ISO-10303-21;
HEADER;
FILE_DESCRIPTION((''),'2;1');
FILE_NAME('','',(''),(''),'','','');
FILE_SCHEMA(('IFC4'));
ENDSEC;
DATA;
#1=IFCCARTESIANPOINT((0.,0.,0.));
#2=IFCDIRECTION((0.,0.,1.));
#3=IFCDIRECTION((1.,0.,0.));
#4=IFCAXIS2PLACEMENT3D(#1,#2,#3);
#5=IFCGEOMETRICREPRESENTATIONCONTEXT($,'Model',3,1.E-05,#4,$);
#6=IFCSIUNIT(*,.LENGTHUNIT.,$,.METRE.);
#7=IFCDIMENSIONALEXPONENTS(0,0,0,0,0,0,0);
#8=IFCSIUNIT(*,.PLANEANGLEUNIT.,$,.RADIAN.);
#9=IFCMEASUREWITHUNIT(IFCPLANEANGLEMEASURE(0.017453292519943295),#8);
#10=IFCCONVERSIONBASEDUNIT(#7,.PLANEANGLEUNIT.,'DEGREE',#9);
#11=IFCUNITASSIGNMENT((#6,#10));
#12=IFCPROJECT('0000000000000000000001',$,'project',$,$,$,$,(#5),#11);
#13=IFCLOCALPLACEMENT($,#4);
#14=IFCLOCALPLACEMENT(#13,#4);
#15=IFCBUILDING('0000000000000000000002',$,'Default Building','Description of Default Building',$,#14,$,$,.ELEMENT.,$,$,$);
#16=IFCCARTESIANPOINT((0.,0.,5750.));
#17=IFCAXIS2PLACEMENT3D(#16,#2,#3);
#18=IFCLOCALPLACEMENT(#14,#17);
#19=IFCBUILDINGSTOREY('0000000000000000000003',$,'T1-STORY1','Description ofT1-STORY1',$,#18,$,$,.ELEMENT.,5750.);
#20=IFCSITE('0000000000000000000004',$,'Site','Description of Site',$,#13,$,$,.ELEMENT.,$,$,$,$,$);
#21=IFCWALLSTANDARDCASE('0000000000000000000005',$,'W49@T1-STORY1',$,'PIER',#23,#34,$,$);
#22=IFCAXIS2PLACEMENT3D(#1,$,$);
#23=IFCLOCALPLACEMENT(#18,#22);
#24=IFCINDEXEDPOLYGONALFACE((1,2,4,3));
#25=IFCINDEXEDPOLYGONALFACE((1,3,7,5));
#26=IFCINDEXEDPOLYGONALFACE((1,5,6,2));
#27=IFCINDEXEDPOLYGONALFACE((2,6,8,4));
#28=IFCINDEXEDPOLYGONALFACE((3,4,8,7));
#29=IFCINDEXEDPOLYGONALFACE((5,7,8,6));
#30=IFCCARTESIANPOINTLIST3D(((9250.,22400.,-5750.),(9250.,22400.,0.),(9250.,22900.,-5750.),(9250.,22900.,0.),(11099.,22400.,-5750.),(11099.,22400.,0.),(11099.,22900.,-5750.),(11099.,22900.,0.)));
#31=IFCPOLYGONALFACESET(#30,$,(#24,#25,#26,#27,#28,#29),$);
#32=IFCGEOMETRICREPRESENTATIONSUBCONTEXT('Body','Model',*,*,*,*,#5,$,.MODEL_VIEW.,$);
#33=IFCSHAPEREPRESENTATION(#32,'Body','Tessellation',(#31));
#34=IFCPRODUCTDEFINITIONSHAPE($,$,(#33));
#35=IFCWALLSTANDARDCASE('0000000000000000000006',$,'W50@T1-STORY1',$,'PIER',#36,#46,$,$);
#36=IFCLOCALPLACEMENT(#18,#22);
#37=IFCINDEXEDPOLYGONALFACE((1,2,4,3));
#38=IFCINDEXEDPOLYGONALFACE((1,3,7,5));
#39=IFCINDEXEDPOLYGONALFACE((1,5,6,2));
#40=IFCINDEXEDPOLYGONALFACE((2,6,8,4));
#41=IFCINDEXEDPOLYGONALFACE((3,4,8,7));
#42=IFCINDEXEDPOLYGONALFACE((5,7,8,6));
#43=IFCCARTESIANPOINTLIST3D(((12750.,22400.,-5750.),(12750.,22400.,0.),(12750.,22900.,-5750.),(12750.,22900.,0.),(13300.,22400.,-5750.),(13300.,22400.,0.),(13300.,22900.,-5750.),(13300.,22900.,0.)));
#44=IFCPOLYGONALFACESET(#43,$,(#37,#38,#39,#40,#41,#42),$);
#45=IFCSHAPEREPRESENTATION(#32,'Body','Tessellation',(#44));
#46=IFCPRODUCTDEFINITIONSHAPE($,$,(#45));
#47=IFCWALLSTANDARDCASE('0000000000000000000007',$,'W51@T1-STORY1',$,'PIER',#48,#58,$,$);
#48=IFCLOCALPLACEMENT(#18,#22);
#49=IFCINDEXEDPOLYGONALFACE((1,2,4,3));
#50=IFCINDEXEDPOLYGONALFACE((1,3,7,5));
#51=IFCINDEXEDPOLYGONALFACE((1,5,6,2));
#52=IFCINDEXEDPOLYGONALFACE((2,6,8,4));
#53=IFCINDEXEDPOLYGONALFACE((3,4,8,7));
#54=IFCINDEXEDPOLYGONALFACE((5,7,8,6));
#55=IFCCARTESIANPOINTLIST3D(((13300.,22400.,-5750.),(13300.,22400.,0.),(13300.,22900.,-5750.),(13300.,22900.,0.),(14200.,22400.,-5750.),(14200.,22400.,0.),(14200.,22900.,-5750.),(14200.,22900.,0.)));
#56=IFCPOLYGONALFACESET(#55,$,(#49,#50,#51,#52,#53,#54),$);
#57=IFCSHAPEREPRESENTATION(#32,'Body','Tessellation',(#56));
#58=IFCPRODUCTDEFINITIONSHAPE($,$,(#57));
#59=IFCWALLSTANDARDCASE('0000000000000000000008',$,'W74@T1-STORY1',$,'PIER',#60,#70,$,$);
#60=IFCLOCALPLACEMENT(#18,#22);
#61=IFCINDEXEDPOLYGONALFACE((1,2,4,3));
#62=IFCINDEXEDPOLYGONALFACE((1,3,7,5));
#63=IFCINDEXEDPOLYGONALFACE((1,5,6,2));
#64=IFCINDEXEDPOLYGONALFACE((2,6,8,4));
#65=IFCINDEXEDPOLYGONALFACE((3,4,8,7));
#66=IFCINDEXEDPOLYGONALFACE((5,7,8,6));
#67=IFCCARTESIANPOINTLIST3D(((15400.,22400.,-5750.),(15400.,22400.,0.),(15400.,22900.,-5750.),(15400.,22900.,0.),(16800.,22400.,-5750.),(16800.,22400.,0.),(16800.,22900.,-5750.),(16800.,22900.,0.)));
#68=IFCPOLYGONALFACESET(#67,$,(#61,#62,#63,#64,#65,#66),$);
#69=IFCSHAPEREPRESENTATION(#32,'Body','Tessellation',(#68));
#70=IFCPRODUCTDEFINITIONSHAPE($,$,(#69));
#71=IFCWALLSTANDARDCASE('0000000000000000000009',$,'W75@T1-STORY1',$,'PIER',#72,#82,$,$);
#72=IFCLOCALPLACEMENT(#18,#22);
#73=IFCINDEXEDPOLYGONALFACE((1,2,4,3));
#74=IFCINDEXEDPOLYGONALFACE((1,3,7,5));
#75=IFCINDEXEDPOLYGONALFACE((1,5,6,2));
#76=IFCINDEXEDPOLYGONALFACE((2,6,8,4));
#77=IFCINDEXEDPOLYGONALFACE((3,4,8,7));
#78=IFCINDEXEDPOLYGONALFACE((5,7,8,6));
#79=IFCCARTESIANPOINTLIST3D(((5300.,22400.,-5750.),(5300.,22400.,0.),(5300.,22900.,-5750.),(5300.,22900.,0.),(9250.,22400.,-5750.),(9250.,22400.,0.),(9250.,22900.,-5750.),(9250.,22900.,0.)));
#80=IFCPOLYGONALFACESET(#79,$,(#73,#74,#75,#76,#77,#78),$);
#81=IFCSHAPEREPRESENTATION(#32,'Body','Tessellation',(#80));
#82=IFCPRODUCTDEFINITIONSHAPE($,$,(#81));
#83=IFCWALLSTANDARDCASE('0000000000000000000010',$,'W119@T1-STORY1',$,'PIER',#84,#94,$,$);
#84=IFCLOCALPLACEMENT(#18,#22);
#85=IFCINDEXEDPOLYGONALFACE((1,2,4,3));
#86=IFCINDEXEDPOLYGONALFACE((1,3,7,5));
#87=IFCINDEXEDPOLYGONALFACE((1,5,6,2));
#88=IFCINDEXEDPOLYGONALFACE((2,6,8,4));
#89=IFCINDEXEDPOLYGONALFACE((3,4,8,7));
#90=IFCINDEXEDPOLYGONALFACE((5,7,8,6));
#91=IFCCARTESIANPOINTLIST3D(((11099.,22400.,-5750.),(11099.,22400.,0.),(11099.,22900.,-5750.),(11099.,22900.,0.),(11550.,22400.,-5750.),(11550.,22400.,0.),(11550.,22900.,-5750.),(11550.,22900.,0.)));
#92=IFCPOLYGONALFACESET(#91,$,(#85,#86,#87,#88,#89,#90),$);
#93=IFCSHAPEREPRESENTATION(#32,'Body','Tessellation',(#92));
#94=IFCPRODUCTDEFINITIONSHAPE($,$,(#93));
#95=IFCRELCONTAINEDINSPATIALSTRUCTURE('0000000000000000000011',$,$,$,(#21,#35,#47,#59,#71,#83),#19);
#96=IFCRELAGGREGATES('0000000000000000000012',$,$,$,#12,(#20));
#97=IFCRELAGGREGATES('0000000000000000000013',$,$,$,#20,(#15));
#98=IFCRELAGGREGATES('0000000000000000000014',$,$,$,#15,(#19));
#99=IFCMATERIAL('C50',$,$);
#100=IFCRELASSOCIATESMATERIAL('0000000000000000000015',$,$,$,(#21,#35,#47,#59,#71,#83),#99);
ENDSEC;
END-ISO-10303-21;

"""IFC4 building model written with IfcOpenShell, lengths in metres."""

from ifc_helpers import new_model, entity, si_unit, converted_unit, frame, origin_with_axes, place, context, subcontext, project, spatial, indexed_curve, outline, extrude, material, element, save


model = new_model("IFC4")

# Units and contexts
model_context = context("Model", 3, precision=1e-05, world=origin_with_axes())
body_context = subcontext(model_context, "Body", "Model", "MODEL_VIEW")
ifc_project = project(units=[si_unit("LENGTHUNIT", "METRE"), converted_unit("PLANEANGLEUNIT", "DEGREE", entity("IfcPlaneAngleMeasure", 0.017453292519943295), si_unit("PLANEANGLEUNIT", "RADIAN"), dimensions=[0, 0, 0, 0, 0, 0, 0])], contexts=[model_context])

# Site, building, storey
site_placement = place(None, origin_with_axes())
site = spatial("IfcSite", under=ifc_project, at=site_placement, Name="Site", Description="Description of Site", CompositionType="ELEMENT")
building_placement = place(site_placement, origin_with_axes())
building = spatial("IfcBuilding", under=site, at=building_placement, Name="Default Building", Description="Description of Default Building", CompositionType="ELEMENT")
storey_placement = place(building_placement, frame((0.0, 0.0, 5750.0), z_axis=(0.0, 0.0, 1.0), x_axis=(1.0, 0.0, 0.0)))
storey = spatial("IfcBuildingStorey", under=building, at=storey_placement, Name="T1-STORY1", Description="Description ofT1-STORY1", CompositionType="ELEMENT", Elevation=5750.0)

# Shared definitions
ifc_material_1 = material(Name="C50")

# Walls
wall_1_placement = place(storey_placement, frame((9250.0, 22650.0, -5750.0), z_axis=(0.0, 0.0, 1.0), x_axis=(1.0, 0.0, 0.0)))
element("IfcWallStandardCase", 1, at=wall_1_placement, inside=storey, material=ifc_material_1, Name="W49@T1-STORY1", ObjectType="PIER", context=body_context, shape_type="SweptSolid", body=[
    extrude(outline(indexed_curve([(0.0, -250.0), (0.0, 250.0), (1849.0, 250.0), (1849.0, -250.0), (0.0, -250.0)], self_intersect=False)), origin_with_axes(), (0.0, 0.0, 1.0), 5750.0),
])
wall_2_placement = place(storey_placement, frame((12750.0, 22650.0, -5750.0), z_axis=(0.0, 0.0, 1.0), x_axis=(1.0, 0.0, 0.0)))
element("IfcWallStandardCase", 2, at=wall_2_placement, inside=storey, material=ifc_material_1, Name="W50@T1-STORY1", ObjectType="PIER", context=body_context, shape_type="SweptSolid", body=[
    extrude(outline(indexed_curve([(0.0, -250.0), (0.0, 250.0), (550.0, 250.0), (550.0, -250.0), (0.0, -250.0)], self_intersect=False)), origin_with_axes(), (0.0, 0.0, 1.0), 5750.0),
])
wall_3_placement = place(storey_placement, frame((13300.0, 22650.0, -5750.0), z_axis=(0.0, 0.0, 1.0), x_axis=(1.0, 0.0, 0.0)))
element("IfcWallStandardCase", 3, at=wall_3_placement, inside=storey, material=ifc_material_1, Name="W51@T1-STORY1", ObjectType="PIER", context=body_context, shape_type="SweptSolid", body=[
    extrude(outline(indexed_curve([(0.0, -250.0), (0.0, 250.0), (900.0, 250.0), (900.0, -250.0), (0.0, -250.0)], self_intersect=False)), origin_with_axes(), (0.0, 0.0, 1.0), 5750.0),
])
wall_4_placement = place(storey_placement, frame((15400.0, 22650.0, -5750.0), z_axis=(0.0, 0.0, 1.0), x_axis=(1.0, 0.0, 0.0)))
element("IfcWallStandardCase", 4, at=wall_4_placement, inside=storey, material=ifc_material_1, Name="W74@T1-STORY1", ObjectType="PIER", context=body_context, shape_type="SweptSolid", body=[
    extrude(outline(indexed_curve([(0.0, -250.0), (0.0, 250.0), (1400.0, 250.0), (1400.0, -250.0), (0.0, -250.0)], self_intersect=False)), origin_with_axes(), (0.0, 0.0, 1.0), 5750.0),
])
wall_5_placement = place(storey_placement, frame((5300.0, 22650.0, -5750.0), z_axis=(0.0, 0.0, 1.0), x_axis=(1.0, 0.0, 0.0)))
element("IfcWallStandardCase", 5, at=wall_5_placement, inside=storey, material=ifc_material_1, Name="W75@T1-STORY1", ObjectType="PIER", context=body_context, shape_type="SweptSolid", body=[
    extrude(outline(indexed_curve([(0.0, -250.0), (0.0, 250.0), (3950.0, 250.0), (3950.0, -250.0), (0.0, -250.0)], self_intersect=False)), origin_with_axes(), (0.0, 0.0, 1.0), 5750.0),
])
wall_6_placement = place(storey_placement, frame((11099.0, 22650.0, -5750.0), z_axis=(0.0, 0.0, 1.0), x_axis=(1.0, 0.0, 0.0)))
element("IfcWallStandardCase", 6, at=wall_6_placement, inside=storey, material=ifc_material_1, Name="W119@T1-STORY1", ObjectType="PIER", context=body_context, shape_type="SweptSolid", body=[
    extrude(outline(indexed_curve([(0.0, -250.0), (0.0, 250.0), (451.0, 250.0), (451.0, -250.0), (0.0, -250.0)], self_intersect=False)), origin_with_axes(), (0.0, 0.0, 1.0), 5750.0),
])

save(model, "model.ifc")
